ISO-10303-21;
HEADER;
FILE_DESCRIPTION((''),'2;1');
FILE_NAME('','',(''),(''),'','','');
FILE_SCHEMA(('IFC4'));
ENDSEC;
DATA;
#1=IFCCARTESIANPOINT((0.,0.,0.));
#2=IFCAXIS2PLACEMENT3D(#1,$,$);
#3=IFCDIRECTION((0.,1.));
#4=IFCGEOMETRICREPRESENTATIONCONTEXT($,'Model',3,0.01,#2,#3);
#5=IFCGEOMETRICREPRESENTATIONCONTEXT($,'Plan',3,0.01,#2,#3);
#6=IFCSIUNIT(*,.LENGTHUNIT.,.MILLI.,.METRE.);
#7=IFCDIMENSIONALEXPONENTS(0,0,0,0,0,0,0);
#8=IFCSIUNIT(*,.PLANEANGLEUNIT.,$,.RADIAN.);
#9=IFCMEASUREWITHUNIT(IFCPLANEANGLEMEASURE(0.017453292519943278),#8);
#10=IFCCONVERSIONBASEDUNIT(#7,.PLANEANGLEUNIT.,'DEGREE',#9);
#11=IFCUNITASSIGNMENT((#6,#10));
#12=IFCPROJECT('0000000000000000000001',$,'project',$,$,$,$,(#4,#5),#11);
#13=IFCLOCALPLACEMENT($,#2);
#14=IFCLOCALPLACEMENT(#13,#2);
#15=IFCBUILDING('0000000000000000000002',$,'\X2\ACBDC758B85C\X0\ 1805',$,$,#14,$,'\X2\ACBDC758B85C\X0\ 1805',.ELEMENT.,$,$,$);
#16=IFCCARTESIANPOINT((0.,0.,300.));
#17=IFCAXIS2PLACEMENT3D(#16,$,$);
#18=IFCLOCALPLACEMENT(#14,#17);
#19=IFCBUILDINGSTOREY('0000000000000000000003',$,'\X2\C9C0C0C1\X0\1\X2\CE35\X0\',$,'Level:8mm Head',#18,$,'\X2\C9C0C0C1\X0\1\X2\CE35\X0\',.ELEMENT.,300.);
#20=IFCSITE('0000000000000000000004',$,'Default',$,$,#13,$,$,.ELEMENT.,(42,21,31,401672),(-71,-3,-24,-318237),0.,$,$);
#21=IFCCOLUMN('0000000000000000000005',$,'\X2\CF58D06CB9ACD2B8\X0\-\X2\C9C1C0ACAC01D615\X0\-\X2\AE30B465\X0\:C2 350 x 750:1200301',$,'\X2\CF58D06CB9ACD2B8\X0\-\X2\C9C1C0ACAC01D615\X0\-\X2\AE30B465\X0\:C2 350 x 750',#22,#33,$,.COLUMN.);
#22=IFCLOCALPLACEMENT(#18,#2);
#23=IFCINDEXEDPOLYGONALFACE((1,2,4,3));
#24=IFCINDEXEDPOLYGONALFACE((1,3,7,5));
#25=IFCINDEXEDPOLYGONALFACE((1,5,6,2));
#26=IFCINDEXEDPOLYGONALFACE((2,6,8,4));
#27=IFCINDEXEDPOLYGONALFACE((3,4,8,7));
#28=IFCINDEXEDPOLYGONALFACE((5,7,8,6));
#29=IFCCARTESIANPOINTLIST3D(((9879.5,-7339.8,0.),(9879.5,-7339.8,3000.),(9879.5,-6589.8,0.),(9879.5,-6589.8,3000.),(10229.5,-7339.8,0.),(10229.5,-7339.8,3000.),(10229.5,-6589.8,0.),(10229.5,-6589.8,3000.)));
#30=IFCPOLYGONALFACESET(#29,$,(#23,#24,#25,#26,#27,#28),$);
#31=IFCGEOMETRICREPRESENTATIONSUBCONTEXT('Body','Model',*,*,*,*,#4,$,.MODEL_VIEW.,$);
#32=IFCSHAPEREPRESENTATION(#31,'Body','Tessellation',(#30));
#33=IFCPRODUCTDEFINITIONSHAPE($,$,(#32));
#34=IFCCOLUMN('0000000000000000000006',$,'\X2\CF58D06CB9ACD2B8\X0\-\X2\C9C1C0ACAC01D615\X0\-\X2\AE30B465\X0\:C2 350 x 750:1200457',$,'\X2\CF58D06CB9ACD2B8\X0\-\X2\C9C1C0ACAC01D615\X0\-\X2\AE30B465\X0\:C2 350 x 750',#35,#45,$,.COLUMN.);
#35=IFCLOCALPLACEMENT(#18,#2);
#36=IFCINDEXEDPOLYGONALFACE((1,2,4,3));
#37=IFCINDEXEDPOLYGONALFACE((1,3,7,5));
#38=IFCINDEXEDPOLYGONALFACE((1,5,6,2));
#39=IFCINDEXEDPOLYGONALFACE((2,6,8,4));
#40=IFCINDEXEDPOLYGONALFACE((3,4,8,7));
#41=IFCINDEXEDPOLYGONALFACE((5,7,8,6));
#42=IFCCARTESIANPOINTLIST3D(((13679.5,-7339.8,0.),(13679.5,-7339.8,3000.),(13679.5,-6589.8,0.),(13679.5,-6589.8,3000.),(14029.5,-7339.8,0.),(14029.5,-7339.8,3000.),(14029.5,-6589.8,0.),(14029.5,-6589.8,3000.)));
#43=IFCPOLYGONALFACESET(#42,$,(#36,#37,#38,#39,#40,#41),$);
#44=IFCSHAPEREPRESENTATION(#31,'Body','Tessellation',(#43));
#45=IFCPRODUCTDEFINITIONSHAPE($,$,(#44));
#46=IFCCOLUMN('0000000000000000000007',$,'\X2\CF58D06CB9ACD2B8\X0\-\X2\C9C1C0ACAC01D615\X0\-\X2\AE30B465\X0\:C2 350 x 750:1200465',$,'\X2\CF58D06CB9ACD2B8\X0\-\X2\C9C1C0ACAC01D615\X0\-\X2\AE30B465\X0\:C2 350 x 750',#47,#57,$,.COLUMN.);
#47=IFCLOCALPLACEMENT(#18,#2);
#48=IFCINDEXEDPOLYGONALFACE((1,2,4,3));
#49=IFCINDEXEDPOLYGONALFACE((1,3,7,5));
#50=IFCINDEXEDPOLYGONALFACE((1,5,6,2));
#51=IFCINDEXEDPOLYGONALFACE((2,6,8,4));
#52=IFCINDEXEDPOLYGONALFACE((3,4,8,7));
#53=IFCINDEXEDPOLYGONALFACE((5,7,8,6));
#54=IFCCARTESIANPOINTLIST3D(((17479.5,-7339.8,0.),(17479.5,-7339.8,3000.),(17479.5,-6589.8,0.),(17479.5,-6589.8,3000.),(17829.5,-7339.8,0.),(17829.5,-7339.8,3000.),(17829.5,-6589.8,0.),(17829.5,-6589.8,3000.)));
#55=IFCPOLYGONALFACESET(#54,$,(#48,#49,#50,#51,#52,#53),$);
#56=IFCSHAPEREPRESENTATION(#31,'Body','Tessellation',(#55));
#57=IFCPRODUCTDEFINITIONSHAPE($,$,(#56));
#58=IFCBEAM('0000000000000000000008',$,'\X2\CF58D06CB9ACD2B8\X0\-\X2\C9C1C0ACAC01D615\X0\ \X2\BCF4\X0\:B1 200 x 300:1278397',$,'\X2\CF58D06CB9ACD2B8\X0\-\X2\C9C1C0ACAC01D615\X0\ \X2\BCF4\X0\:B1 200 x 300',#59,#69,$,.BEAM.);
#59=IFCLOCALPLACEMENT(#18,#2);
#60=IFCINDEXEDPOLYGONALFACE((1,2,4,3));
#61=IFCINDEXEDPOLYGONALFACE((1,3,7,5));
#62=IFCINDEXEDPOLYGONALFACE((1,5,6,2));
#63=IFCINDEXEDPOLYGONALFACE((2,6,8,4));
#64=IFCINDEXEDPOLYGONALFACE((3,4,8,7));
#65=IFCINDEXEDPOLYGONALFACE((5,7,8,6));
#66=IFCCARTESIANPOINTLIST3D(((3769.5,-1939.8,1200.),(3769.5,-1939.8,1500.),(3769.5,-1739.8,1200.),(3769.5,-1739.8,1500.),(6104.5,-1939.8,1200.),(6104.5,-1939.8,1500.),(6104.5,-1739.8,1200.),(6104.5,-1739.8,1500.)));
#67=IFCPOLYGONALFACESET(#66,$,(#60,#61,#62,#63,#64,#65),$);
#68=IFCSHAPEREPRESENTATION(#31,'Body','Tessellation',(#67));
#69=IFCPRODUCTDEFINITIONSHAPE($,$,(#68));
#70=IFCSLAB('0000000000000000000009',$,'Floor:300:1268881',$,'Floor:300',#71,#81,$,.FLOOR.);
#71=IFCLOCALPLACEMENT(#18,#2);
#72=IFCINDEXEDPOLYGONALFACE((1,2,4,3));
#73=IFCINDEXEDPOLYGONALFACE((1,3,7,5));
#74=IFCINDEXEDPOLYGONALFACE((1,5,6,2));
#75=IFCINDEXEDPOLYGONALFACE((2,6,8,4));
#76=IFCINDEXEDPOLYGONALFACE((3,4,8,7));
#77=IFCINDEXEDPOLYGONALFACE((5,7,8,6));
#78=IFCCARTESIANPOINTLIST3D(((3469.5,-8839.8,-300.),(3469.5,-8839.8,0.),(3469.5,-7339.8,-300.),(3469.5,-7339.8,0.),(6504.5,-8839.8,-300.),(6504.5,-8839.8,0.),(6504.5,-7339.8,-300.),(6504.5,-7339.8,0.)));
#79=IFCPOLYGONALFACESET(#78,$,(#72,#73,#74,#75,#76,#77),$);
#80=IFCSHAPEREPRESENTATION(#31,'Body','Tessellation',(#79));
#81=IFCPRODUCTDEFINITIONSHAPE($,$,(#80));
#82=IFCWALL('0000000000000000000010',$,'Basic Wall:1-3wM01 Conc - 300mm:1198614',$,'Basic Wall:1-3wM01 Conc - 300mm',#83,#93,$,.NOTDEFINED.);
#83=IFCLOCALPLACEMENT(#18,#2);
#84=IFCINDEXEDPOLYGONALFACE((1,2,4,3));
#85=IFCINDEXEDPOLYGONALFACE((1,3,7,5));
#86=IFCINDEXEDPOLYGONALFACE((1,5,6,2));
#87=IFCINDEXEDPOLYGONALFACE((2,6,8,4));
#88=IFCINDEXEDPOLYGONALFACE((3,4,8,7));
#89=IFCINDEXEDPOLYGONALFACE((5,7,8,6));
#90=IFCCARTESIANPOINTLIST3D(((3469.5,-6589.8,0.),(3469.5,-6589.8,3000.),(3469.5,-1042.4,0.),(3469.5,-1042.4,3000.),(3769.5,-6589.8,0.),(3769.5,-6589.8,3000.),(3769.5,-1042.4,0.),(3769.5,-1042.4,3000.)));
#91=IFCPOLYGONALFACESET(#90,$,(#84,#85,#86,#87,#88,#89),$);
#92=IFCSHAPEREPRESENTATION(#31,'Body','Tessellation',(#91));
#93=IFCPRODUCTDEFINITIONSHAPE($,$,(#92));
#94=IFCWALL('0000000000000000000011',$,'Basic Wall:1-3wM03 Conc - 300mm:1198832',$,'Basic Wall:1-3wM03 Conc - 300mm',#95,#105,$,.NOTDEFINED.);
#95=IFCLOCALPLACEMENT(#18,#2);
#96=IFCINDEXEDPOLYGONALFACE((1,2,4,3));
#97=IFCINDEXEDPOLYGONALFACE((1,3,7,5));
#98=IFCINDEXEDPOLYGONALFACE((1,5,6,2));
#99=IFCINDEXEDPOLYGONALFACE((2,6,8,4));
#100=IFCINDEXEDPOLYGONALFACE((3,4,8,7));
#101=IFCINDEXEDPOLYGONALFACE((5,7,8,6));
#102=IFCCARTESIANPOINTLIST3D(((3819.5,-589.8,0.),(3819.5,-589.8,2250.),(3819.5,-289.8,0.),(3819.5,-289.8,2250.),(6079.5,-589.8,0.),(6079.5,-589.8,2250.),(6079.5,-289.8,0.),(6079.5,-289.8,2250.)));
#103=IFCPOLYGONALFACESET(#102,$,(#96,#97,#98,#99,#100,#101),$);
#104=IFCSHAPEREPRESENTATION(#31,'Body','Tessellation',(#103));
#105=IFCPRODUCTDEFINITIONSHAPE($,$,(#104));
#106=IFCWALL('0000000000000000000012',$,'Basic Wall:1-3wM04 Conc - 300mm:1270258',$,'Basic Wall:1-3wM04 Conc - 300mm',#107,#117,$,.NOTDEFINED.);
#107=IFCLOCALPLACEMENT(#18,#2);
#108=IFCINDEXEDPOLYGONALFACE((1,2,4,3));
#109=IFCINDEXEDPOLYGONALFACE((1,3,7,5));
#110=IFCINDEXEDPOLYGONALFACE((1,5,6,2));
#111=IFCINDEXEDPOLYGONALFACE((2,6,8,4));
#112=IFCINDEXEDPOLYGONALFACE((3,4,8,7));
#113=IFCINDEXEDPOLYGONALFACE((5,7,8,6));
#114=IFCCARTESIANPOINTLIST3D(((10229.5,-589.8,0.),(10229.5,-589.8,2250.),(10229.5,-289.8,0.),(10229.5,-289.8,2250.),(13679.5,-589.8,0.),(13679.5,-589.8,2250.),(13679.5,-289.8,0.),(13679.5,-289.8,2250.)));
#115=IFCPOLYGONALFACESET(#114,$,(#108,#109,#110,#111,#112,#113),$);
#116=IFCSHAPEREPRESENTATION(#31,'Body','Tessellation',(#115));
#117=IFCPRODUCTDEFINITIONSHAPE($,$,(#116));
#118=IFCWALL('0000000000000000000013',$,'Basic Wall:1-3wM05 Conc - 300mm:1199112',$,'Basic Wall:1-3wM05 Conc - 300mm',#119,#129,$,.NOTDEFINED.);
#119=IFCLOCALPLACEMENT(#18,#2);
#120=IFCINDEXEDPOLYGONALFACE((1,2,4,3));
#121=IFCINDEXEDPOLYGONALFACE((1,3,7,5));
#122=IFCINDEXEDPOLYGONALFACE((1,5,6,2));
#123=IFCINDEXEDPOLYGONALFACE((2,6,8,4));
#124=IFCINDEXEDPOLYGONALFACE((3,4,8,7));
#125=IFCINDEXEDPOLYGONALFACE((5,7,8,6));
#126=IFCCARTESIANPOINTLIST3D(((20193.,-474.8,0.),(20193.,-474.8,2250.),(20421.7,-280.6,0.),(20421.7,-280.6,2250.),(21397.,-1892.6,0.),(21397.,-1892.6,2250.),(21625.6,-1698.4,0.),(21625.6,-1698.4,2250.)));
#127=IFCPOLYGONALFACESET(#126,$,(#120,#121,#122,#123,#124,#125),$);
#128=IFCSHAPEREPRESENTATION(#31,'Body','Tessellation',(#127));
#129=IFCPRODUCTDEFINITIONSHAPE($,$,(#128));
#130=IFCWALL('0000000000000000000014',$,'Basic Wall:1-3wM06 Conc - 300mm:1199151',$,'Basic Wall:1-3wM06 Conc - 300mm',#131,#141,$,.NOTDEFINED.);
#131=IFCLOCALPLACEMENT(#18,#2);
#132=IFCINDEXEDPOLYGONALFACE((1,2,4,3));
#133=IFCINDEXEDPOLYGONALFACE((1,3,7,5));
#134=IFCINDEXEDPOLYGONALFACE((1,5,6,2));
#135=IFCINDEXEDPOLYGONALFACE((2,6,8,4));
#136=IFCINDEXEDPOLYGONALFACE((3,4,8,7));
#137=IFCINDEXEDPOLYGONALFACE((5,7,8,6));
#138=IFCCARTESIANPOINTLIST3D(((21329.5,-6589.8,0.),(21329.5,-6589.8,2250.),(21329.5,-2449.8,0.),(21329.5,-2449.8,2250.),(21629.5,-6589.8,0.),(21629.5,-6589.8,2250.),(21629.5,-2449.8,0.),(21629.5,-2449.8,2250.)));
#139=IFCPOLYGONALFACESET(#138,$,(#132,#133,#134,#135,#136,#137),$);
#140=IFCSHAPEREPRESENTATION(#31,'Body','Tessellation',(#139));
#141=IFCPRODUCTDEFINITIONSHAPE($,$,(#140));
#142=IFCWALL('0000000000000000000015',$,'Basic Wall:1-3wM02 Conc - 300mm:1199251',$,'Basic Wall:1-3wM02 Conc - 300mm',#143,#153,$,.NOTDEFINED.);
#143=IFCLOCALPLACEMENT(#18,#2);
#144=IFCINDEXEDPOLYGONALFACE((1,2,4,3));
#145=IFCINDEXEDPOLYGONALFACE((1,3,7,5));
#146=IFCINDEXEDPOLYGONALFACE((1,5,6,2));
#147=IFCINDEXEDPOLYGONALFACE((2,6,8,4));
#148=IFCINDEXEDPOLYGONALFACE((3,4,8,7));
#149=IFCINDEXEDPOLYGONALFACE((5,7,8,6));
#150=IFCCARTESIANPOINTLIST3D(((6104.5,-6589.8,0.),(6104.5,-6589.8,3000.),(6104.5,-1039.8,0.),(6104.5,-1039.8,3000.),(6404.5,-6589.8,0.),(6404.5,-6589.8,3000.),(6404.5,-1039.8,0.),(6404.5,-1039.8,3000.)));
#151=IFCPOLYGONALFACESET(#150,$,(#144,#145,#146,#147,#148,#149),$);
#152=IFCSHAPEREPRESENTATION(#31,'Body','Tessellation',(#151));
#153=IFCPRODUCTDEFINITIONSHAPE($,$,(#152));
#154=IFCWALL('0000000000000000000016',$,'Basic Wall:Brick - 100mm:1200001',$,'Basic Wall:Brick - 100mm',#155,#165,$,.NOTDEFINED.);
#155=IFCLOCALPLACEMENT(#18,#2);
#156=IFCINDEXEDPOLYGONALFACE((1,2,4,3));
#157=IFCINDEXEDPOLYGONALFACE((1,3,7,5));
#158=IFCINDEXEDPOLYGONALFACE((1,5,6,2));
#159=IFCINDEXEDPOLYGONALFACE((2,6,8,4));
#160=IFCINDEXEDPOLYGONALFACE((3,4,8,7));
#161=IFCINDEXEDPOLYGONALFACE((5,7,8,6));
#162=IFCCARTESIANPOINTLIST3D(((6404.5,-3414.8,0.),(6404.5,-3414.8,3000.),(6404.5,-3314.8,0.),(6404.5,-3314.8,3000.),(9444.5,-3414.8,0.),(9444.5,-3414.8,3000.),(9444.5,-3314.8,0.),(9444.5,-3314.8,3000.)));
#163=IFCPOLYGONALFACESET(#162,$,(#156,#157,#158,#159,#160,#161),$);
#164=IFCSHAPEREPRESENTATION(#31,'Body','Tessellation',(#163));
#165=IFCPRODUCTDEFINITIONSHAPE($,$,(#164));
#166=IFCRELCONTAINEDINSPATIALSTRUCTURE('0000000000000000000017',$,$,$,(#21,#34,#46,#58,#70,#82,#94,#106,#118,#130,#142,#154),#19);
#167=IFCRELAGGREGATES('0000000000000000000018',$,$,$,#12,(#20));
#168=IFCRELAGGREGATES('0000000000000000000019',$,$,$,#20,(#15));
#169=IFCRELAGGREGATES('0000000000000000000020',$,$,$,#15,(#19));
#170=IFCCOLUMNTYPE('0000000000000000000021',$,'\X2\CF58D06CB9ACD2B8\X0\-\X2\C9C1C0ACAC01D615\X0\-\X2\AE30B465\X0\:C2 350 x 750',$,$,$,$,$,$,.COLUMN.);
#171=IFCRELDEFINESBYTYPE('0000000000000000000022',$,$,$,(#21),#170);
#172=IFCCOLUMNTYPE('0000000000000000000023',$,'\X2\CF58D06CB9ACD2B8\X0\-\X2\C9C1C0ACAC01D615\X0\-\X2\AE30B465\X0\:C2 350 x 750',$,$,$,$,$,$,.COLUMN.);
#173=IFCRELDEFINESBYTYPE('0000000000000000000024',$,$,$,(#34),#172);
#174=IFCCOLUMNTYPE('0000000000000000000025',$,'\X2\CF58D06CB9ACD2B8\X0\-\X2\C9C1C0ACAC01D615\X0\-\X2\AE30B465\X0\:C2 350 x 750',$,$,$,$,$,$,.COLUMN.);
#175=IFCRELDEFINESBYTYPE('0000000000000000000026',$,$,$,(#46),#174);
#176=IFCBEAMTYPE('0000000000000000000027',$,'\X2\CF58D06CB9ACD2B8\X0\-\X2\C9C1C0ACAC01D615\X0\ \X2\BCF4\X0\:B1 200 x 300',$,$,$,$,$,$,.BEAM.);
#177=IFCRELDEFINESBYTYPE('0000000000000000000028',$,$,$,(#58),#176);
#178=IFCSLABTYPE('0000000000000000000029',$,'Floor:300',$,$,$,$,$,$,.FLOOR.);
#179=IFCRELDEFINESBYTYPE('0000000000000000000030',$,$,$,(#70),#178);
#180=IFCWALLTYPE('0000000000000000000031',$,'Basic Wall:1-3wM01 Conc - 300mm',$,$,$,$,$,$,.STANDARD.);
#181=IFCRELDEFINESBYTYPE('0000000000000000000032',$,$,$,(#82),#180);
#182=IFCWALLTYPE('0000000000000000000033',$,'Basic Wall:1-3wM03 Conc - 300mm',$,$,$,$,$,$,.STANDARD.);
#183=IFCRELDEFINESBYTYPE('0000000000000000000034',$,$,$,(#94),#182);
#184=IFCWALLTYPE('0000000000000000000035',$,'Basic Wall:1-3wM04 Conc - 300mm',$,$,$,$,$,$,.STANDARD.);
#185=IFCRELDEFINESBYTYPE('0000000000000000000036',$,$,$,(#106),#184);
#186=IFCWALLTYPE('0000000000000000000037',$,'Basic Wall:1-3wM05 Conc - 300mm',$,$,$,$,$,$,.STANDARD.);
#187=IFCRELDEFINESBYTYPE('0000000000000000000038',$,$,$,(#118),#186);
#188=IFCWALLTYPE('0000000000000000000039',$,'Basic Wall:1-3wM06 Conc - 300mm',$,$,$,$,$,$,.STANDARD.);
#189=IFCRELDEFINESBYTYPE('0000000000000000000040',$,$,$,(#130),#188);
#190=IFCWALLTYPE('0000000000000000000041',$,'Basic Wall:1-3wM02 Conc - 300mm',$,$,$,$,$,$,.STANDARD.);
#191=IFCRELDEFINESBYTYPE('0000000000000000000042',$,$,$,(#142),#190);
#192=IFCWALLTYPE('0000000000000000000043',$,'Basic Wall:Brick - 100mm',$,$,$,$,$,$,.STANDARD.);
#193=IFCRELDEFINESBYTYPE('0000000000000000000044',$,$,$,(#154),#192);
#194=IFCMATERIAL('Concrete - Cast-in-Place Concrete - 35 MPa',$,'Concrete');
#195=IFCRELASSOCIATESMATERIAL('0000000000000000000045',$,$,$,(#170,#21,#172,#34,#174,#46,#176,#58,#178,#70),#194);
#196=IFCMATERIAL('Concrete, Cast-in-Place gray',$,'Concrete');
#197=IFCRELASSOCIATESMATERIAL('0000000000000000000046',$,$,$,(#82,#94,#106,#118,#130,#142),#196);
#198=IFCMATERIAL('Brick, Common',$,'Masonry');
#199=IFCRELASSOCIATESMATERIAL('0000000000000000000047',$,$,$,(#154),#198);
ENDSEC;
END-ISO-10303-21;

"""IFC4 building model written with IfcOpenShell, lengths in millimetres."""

from ifc_helpers import new_model, entity, si_unit, converted_unit, direction, frame, origin, place, context, subcontext, project, spatial, indexed_curve, outline, extrude, source, transform, mapped, material, type_object, type_shapes, element, save


model = new_model("IFC4")

# Units and contexts
model_context = context("Model", 3, precision=0.01, world=origin(), true_north=direction((0.0, 1.0)))
plan_context = context("Plan", 3, precision=0.01, world=origin(), true_north=direction((0.0, 1.0)))
body_context = subcontext(model_context, "Body", "Model", "MODEL_VIEW")
ifc_project = project(units=[si_unit("LENGTHUNIT", "METRE", prefix="MILLI"), converted_unit("PLANEANGLEUNIT", "DEGREE", entity("IfcPlaneAngleMeasure", 0.017453292519943278), si_unit("PLANEANGLEUNIT", "RADIAN"), dimensions=[0, 0, 0, 0, 0, 0, 0])], contexts=[model_context, plan_context])

# Site, building, storey
site_placement = place(None, origin())
site = spatial("IfcSite", under=ifc_project, at=site_placement, Name="Default", CompositionType="ELEMENT", RefLatitude=(42, 21, 31, 401672), RefLongitude=(-71, -3, -24, -318237), RefElevation=0.0)
building_placement = place(site_placement, origin())
building = spatial("IfcBuilding", under=site, at=building_placement, Name="경의로 1805", LongName="경의로 1805", CompositionType="ELEMENT")
storey_placement = place(building_placement, frame((0.0, 0.0, 300.0)))
storey = spatial("IfcBuildingStorey", under=building, at=storey_placement, Name="지상1층", ObjectType="Level:8mm Head", LongName="지상1층", CompositionType="ELEMENT", Elevation=300.0)

# Columns
ifc_material_1 = material(Name="Concrete - Cast-in-Place Concrete - 35 MPa", Category="Concrete")
column_type_1 = type_object("IfcColumnType", Name="콘크리트-직사각형-기둥:C2 350 x 750", PredefinedType="COLUMN", material=ifc_material_1)
shared_shape_1 = source(origin(), body_context, "Body", "SweptSolid", [
    extrude(outline(indexed_curve([(-175.0, -375.0), (175.0, -375.0), (175.0, 375.0), (-175.0, 375.0), (-175.0, -375.0)], self_intersect=False)), frame((10054.5, -6964.8, 300.0), z_axis=(0.0, 0.0, 1.0), x_axis=(-1.0, 0.0, 0.0)), (0.0, 0.0, 1.0), 3000.0),
])
type_shapes(column_type_1, [shared_shape_1])
column_1_placement = place(storey_placement, frame((0.0, 0.0, -300.0)))
element("IfcColumn", 1, at=column_1_placement, inside=storey, type_object=column_type_1, material=ifc_material_1, Name="콘크리트-직사각형-기둥:C2 350 x 750:1200301", ObjectType="콘크리트-직사각형-기둥:C2 350 x 750", PredefinedType="COLUMN", context=body_context, shape_type="MappedRepresentation", body=[
    mapped(shared_shape_1, transform((0.0, 0.0, 0.0), scale=1.0)),
])
column_type_2 = type_object("IfcColumnType", Name="콘크리트-직사각형-기둥:C2 350 x 750", PredefinedType="COLUMN", material=ifc_material_1)
shared_shape_2 = source(origin(), body_context, "Body", "SweptSolid", [
    extrude(outline(indexed_curve([(-175.0, -375.0), (175.0, -375.0), (175.0, 375.0), (-175.0, 375.0), (-175.0, -375.0)], self_intersect=False)), frame((13854.5, -6964.8, 300.0), z_axis=(0.0, 0.0, 1.0), x_axis=(-1.0, 0.0, 0.0)), (0.0, 0.0, 1.0), 3000.0),
])
type_shapes(column_type_2, [shared_shape_2])
column_2_placement = place(storey_placement, frame((0.0, 0.0, -300.0)))
element("IfcColumn", 2, at=column_2_placement, inside=storey, type_object=column_type_2, material=ifc_material_1, Name="콘크리트-직사각형-기둥:C2 350 x 750:1200457", ObjectType="콘크리트-직사각형-기둥:C2 350 x 750", PredefinedType="COLUMN", context=body_context, shape_type="MappedRepresentation", body=[
    mapped(shared_shape_2, transform((0.0, 0.0, 0.0), scale=1.0)),
])
column_type_3 = type_object("IfcColumnType", Name="콘크리트-직사각형-기둥:C2 350 x 750", PredefinedType="COLUMN", material=ifc_material_1)
shared_shape_3 = source(origin(), body_context, "Body", "SweptSolid", [
    extrude(outline(indexed_curve([(-175.0, -375.0), (175.0, -375.0), (175.0, 375.0), (-175.0, 375.0), (-175.0, -375.0)], self_intersect=False)), frame((17654.5, -6964.8, 300.0), z_axis=(0.0, 0.0, 1.0), x_axis=(-1.0, 0.0, 0.0)), (0.0, 0.0, 1.0), 3000.0),
])
type_shapes(column_type_3, [shared_shape_3])
column_3_placement = place(storey_placement, frame((0.0, 0.0, -300.0)))
element("IfcColumn", 3, at=column_3_placement, inside=storey, type_object=column_type_3, material=ifc_material_1, Name="콘크리트-직사각형-기둥:C2 350 x 750:1200465", ObjectType="콘크리트-직사각형-기둥:C2 350 x 750", PredefinedType="COLUMN", context=body_context, shape_type="MappedRepresentation", body=[
    mapped(shared_shape_3, transform((0.0, 0.0, 0.0), scale=1.0)),
])

# Beam
beam_type = type_object("IfcBeamType", Name="콘크리트-직사각형 보:B1 200 x 300", PredefinedType="BEAM", material=ifc_material_1)
shared_shape_4 = source(origin(), body_context, "Body", "SweptSolid", [
    extrude(outline(indexed_curve([(-150.0, -100.0), (150.0, -100.0), (150.0, 100.0), (-150.0, 100.0), (-150.0, -100.0)], self_intersect=False)), frame((3769.5, -1839.8, 1650.0), z_axis=(1.0, 0.0, 0.0), x_axis=(0.0, 0.0, -1.0)), (0.0, 0.0, 1.0), 2335.0),
])
type_shapes(beam_type, [shared_shape_4])
beam_placement = place(storey_placement, frame((0.0, 0.0, -300.0)))
element("IfcBeam", 4, at=beam_placement, inside=storey, type_object=beam_type, material=ifc_material_1, Name="콘크리트-직사각형 보:B1 200 x 300:1278397", ObjectType="콘크리트-직사각형 보:B1 200 x 300", PredefinedType="BEAM", context=body_context, shape_type="MappedRepresentation", body=[
    mapped(shared_shape_4, transform((0.0, 0.0, 0.0), scale=1.0)),
])

# Slab
slab_type_1 = type_object("IfcSlabType", Name="Floor:300", PredefinedType="FLOOR", material=ifc_material_1)
slab_1_placement = place(storey_placement, origin())
element("IfcSlab", 5, at=slab_1_placement, inside=storey, type_object=slab_type_1, material=ifc_material_1, Name="Floor:300:1268881", ObjectType="Floor:300", PredefinedType="FLOOR", context=body_context, shape_type="SweptSolid", body=[
    extrude(outline(indexed_curve([(-750.0, -1517.5), (750.0, -1517.5), (750.0, 1517.5), (-750.0, 1517.5), (-750.0, -1517.5)], self_intersect=False)), frame((4987.0, -8089.8, 0.0), z_axis=(0.0, 0.0, -1.0), x_axis=(0.0, 1.0, 0.0)), (0.0, 0.0, 1.0), 300.0),
])

# Walls
ifc_material_2 = material(Name="Concrete, Cast-in-Place gray", Category="Concrete")
wall_type_1 = type_object("IfcWallType", Name="Basic Wall:1-3wM01 Conc - 300mm", PredefinedType="STANDARD")
wall_1_placement = place(storey_placement, frame((3619.5, -6589.8, 0.0), z_axis=(0.0, 0.0, 1.0), x_axis=(0.0, 1.0, 0.0)))
element("IfcWall", 6, at=wall_1_placement, inside=storey, type_object=wall_type_1, material=ifc_material_2, Name="Basic Wall:1-3wM01 Conc - 300mm:1198614", ObjectType="Basic Wall:1-3wM01 Conc - 300mm", PredefinedType="NOTDEFINED", context=body_context, shape_type="SweptSolid", body=[
    extrude(outline(indexed_curve([(5547.4, 150.0), (0.0, 150.0), (0.0, -150.0), (5547.4, -150.0), (5547.4, 150.0)], self_intersect=False)), origin(), (0.0, 0.0, 1.0), 3000.0),
])
wall_type_2 = type_object("IfcWallType", Name="Basic Wall:1-3wM03 Conc - 300mm", PredefinedType="STANDARD")
wall_2_placement = place(storey_placement, frame((3819.5, -439.8, 0.0)))
element("IfcWall", 7, at=wall_2_placement, inside=storey, type_object=wall_type_2, material=ifc_material_2, Name="Basic Wall:1-3wM03 Conc - 300mm:1198832", ObjectType="Basic Wall:1-3wM03 Conc - 300mm", PredefinedType="NOTDEFINED", context=body_context, shape_type="SweptSolid", body=[
    extrude(outline(indexed_curve([(2260.0, 150.0), (0.0, 150.0), (0.0, -150.0), (2260.0, -150.0), (2260.0, 150.0)], self_intersect=False)), origin(), (0.0, 0.0, 1.0), 2250.0),
])
wall_type_3 = type_object("IfcWallType", Name="Basic Wall:1-3wM04 Conc - 300mm", PredefinedType="STANDARD")
wall_3_placement = place(storey_placement, frame((10229.5, -439.8, 0.0)))
element("IfcWall", 8, at=wall_3_placement, inside=storey, type_object=wall_type_3, material=ifc_material_2, Name="Basic Wall:1-3wM04 Conc - 300mm:1270258", ObjectType="Basic Wall:1-3wM04 Conc - 300mm", PredefinedType="NOTDEFINED", context=body_context, shape_type="SweptSolid", body=[
    extrude(outline(indexed_curve([(3450.0, 150.0), (0.0, 150.0), (0.0, -150.0), (3450.0, -150.0), (3450.0, 150.0)], self_intersect=False)), origin(), (0.0, 0.0, 1.0), 2250.0),
])
wall_type_4 = type_object("IfcWallType", Name="Basic Wall:1-3wM05 Conc - 300mm", PredefinedType="STANDARD")
wall_4_placement = place(storey_placement, frame((20307.3, -377.7, 0.0), z_axis=(0.0, 0.0, 1.0), x_axis=(0.647298, -0.762237, 0.0)))
element("IfcWall", 9, at=wall_4_placement, inside=storey, type_object=wall_type_4, material=ifc_material_2, Name="Basic Wall:1-3wM05 Conc - 300mm:1199112", ObjectType="Basic Wall:1-3wM05 Conc - 300mm", PredefinedType="NOTDEFINED", context=body_context, shape_type="SweptSolid", body=[
    extrude(outline(indexed_curve([(1860.0, 150.0), (0.0, 150.0), (0.0, -150.0), (1860.0, -150.0), (1860.0, 150.0)], self_intersect=False)), origin(), (0.0, 0.0, 1.0), 2250.0),
])
wall_type_5 = type_object("IfcWallType", Name="Basic Wall:1-3wM06 Conc - 300mm", PredefinedType="STANDARD")
wall_5_placement = place(storey_placement, frame((21479.5, -2449.8, 0.0), z_axis=(0.0, 0.0, 1.0), x_axis=(0.0, -1.0, 0.0)))
element("IfcWall", 10, at=wall_5_placement, inside=storey, type_object=wall_type_5, material=ifc_material_2, Name="Basic Wall:1-3wM06 Conc - 300mm:1199151", ObjectType="Basic Wall:1-3wM06 Conc - 300mm", PredefinedType="NOTDEFINED", context=body_context, shape_type="SweptSolid", body=[
    extrude(outline(indexed_curve([(4140.0, 150.0), (0.0, 150.0), (0.0, -150.0), (4140.0, -150.0), (4140.0, 150.0)], self_intersect=False)), origin(), (0.0, 0.0, 1.0), 2250.0),
])
wall_type_6 = type_object("IfcWallType", Name="Basic Wall:1-3wM02 Conc - 300mm", PredefinedType="STANDARD")
wall_6_placement = place(storey_placement, frame((6254.5, -1039.8, 0.0), z_axis=(0.0, 0.0, 1.0), x_axis=(0.0, -1.0, 0.0)))
element("IfcWall", 11, at=wall_6_placement, inside=storey, type_object=wall_type_6, material=ifc_material_2, Name="Basic Wall:1-3wM02 Conc - 300mm:1199251", ObjectType="Basic Wall:1-3wM02 Conc - 300mm", PredefinedType="NOTDEFINED", context=body_context, shape_type="SweptSolid", body=[
    extrude(outline(indexed_curve([(5550.0, 150.0), (0.0, 150.0), (0.0, -150.0), (5550.0, -150.0), (5550.0, 150.0)], self_intersect=False)), origin(), (0.0, 0.0, 1.0), 3000.0),
])
ifc_material_3 = material(Name="Brick, Common", Category="Masonry")
wall_type_7 = type_object("IfcWallType", Name="Basic Wall:Brick - 100mm", PredefinedType="STANDARD")
wall_7_placement = place(storey_placement, frame((6404.5, -3364.8, 0.0)))
element("IfcWall", 12, at=wall_7_placement, inside=storey, type_object=wall_type_7, material=ifc_material_3, Name="Basic Wall:Brick - 100mm:1200001", ObjectType="Basic Wall:Brick - 100mm", PredefinedType="NOTDEFINED", context=body_context, shape_type="SweptSolid", body=[
    extrude(outline(indexed_curve([(3040.0, 50.0), (0.0, 50.0), (0.0, -50.0), (3040.0, -50.0), (3040.0, 50.0)], self_intersect=False)), origin(), (0.0, 0.0, 1.0), 3000.0),
])

save(model, "model.ifc")
